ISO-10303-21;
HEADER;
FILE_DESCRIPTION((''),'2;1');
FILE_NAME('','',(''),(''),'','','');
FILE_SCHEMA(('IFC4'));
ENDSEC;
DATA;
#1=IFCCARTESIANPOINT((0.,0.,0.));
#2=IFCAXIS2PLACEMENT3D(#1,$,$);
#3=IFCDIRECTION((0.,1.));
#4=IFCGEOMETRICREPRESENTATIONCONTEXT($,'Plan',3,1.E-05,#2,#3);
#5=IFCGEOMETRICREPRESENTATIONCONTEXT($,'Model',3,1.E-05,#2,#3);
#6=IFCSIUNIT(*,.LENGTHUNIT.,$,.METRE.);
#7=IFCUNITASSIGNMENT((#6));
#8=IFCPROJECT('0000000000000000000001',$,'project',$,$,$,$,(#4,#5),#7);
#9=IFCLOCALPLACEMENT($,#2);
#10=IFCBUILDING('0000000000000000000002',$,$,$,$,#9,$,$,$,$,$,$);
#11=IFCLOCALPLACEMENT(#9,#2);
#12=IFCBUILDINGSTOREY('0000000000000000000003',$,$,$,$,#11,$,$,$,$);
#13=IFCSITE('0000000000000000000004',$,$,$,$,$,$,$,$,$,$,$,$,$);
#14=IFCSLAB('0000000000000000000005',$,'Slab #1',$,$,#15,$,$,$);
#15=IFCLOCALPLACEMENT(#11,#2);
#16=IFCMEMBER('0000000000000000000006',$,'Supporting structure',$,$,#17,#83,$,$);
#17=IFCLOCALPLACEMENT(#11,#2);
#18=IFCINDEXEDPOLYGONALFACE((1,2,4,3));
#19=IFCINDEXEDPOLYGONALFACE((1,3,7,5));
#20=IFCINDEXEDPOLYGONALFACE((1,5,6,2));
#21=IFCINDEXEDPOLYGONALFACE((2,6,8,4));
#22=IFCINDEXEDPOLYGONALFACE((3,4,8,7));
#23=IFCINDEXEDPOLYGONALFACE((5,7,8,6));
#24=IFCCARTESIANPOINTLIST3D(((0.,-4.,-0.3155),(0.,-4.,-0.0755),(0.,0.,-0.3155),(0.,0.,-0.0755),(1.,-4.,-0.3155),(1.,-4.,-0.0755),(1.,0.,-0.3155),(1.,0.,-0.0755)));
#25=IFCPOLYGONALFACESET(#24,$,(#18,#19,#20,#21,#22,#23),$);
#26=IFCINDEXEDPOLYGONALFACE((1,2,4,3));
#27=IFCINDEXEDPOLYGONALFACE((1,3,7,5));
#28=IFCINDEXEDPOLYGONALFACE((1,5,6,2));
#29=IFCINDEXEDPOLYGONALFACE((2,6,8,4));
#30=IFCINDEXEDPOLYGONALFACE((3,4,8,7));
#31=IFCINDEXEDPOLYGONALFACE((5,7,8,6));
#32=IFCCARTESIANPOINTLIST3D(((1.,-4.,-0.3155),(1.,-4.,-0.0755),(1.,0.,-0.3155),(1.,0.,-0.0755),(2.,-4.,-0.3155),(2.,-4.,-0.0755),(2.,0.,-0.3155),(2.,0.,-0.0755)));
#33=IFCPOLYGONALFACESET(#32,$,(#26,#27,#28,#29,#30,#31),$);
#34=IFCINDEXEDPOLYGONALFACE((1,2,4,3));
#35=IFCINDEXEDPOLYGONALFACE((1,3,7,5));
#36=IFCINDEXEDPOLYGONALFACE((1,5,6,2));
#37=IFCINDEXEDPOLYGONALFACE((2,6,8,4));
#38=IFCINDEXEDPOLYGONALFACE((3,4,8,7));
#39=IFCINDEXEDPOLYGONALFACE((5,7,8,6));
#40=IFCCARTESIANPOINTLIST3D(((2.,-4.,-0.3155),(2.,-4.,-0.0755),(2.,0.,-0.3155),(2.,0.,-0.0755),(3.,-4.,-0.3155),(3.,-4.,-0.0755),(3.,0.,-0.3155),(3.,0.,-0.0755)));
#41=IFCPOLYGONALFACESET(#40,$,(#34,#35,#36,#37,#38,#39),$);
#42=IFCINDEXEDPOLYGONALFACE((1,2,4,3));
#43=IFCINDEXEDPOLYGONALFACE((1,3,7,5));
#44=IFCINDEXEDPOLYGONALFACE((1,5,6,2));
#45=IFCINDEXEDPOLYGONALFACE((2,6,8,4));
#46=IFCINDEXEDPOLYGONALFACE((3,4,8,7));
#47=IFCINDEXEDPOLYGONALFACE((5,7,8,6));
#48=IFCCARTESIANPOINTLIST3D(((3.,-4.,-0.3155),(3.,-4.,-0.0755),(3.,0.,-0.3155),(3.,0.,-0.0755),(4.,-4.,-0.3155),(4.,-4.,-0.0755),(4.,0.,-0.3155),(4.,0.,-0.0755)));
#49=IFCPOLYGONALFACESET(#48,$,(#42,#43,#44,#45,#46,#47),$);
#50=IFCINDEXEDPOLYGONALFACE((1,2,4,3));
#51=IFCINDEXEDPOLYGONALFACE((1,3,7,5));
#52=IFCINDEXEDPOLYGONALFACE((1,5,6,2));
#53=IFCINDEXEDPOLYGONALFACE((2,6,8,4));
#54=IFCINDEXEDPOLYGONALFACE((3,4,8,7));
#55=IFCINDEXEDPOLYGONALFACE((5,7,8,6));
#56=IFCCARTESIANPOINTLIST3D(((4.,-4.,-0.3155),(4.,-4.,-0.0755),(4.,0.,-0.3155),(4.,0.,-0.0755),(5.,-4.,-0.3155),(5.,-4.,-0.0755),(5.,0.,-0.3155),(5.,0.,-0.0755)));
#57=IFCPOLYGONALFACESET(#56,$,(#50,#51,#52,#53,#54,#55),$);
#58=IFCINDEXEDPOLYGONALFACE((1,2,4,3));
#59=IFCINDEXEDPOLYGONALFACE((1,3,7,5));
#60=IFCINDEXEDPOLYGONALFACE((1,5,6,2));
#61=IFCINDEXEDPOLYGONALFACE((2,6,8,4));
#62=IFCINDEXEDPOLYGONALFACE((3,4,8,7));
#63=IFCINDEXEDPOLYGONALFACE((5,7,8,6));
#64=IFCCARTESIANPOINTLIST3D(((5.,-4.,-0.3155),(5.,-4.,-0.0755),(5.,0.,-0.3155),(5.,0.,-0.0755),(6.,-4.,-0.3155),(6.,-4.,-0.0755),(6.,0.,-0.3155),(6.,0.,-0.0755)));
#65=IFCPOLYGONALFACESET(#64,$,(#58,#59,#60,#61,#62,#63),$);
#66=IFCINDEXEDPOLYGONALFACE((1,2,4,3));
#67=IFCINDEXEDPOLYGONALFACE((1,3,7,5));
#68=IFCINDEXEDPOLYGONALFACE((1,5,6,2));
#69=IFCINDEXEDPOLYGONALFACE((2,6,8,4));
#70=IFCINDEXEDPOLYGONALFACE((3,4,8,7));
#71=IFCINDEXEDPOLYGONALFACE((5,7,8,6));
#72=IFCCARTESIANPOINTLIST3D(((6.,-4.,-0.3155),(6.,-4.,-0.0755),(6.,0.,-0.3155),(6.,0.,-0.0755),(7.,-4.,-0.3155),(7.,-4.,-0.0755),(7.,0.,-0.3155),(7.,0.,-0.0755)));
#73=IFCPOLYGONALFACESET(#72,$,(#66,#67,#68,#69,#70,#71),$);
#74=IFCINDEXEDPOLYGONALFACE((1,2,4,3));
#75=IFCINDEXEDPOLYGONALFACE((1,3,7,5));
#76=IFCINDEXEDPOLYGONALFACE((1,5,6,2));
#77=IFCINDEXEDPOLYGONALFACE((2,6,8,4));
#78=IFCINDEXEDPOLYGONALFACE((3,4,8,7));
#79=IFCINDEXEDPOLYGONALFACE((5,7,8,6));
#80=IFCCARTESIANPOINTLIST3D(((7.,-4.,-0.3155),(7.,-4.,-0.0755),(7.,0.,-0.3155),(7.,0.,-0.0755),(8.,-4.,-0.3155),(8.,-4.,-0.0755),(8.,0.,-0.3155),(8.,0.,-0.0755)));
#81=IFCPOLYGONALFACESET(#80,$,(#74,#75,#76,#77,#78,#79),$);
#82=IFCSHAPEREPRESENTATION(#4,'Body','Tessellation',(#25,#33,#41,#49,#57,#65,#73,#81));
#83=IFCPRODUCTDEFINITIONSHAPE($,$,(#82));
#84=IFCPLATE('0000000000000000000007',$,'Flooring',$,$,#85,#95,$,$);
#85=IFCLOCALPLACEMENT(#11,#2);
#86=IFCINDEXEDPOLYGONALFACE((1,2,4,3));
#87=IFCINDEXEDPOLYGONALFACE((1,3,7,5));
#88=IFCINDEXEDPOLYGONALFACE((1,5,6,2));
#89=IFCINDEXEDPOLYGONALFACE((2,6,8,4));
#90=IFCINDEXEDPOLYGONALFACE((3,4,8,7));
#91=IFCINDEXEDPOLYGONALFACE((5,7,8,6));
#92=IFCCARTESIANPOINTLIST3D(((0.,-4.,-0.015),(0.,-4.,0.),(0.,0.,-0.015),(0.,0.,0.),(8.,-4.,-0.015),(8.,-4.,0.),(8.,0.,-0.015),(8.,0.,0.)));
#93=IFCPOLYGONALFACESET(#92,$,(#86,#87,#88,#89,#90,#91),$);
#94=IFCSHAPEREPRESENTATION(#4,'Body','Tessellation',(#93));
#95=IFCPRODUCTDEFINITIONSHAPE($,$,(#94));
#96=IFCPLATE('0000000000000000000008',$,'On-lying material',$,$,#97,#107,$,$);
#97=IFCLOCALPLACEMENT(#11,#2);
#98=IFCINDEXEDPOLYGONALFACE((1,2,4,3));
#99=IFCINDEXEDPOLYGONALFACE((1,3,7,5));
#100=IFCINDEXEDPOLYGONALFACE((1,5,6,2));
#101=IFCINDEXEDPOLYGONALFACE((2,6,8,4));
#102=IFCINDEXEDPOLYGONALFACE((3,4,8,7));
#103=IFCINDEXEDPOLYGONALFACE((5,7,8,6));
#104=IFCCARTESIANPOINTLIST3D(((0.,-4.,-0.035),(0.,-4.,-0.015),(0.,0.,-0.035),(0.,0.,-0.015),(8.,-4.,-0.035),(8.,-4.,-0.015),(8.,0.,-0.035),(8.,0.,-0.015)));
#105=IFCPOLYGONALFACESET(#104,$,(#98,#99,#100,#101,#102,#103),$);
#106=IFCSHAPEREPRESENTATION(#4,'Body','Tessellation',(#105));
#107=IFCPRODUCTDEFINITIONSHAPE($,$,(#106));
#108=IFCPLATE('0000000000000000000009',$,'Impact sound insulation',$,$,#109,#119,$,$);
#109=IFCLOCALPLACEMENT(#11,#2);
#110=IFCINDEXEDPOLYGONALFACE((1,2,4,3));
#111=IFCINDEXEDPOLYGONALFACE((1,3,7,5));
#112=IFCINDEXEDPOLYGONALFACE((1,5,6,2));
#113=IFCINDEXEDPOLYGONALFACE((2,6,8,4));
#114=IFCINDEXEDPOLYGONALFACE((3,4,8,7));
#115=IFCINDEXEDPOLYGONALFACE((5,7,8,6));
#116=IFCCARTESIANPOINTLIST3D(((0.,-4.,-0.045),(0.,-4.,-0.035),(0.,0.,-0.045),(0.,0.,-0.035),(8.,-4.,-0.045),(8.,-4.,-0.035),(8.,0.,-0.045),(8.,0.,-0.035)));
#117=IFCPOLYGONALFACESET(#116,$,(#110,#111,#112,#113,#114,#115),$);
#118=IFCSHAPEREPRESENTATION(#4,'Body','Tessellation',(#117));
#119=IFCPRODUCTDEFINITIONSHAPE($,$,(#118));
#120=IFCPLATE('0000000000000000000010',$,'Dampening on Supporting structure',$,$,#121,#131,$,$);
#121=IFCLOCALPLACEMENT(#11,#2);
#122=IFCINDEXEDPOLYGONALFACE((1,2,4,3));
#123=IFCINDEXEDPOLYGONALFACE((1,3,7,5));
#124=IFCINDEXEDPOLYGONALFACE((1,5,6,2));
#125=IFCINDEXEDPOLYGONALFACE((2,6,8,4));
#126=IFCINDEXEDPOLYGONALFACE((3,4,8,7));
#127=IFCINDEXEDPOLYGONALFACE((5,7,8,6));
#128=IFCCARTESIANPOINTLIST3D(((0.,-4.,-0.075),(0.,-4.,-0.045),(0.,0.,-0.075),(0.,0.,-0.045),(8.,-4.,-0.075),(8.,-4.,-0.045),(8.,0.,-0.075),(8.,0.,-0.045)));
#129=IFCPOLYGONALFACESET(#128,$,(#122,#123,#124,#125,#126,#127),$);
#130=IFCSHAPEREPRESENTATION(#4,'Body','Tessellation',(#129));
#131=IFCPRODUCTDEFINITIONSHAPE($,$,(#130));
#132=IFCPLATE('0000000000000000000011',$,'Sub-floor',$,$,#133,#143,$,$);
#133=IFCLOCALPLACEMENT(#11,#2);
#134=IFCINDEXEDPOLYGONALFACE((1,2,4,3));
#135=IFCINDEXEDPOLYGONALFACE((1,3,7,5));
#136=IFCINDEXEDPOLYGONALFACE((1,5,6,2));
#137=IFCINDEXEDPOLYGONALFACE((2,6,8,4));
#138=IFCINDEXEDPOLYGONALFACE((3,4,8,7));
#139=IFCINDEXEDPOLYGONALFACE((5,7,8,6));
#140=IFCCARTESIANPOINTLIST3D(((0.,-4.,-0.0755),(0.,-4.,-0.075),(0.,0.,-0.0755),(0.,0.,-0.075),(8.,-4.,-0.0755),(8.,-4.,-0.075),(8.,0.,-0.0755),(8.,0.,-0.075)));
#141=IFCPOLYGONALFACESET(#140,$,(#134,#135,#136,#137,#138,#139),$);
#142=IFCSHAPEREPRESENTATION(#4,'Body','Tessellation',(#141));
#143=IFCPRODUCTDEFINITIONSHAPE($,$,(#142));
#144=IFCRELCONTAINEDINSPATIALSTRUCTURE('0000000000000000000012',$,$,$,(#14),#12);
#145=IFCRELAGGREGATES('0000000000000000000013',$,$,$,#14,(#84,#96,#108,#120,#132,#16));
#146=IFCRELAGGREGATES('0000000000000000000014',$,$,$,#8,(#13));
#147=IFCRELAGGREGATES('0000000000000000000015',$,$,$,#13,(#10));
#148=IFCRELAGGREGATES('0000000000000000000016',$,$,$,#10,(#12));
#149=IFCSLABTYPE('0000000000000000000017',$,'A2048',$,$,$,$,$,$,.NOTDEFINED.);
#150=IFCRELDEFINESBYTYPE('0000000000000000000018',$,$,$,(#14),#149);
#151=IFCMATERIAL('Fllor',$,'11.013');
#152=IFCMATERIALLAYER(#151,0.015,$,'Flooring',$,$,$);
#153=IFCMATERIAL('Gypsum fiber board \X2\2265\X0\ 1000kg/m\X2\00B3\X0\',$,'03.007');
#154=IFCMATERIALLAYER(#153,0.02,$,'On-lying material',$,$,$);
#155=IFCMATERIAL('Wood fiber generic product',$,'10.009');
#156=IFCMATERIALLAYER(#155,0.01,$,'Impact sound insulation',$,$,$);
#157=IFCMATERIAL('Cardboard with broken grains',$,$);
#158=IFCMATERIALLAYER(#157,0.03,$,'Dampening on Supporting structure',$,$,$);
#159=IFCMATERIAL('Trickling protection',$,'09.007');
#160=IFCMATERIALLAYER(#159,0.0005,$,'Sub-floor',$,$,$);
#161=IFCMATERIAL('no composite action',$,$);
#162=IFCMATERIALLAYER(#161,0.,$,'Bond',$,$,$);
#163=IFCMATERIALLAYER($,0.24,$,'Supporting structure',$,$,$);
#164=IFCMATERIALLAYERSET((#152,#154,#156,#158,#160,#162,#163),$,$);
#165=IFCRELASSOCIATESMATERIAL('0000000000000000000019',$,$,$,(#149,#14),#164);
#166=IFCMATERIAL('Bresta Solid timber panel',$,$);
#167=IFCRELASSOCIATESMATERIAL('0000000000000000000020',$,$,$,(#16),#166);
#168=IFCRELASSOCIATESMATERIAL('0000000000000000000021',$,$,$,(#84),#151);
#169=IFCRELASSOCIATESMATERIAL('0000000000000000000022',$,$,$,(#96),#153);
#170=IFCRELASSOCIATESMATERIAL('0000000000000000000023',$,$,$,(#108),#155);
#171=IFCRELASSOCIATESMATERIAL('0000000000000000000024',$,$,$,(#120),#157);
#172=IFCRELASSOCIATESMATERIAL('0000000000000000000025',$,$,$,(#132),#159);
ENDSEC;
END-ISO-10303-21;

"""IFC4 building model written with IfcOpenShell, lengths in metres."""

from ifc_helpers import new_model, si_unit, direction, frame, frame_2d, origin, origin_with_axes, place, context, project, spatial, rectangle, extrude, material, layer, layer_set, type_object, element, aggregate, save


model = new_model("IFC4")

# Units and contexts
plan_context = context("Plan", 3, precision=1e-05, world=origin(), true_north=direction((0.0, 1.0)))
model_context = context("Model", 3, precision=1e-05, world=origin(), true_north=direction((0.0, 1.0)))
ifc_project = project(units=[si_unit("LENGTHUNIT", "METRE")], contexts=[plan_context, model_context])

# Site, building, storey
site = spatial("IfcSite", under=ifc_project)
building_placement = place(None, origin())
building = spatial("IfcBuilding", under=site, at=building_placement)
storey_placement = place(building_placement, origin())
storey = spatial("IfcBuildingStorey", under=building, at=storey_placement)

# Slab, member, plates
ifc_material_1 = material(Name="Fllor", Category="11.013")
ifc_layer_1 = layer(ifc_material_1, 0.015, Name="Flooring")
ifc_material_2 = material(Name="Gypsum fiber board ≥ 1000kg/m³", Category="03.007")
ifc_layer_2 = layer(ifc_material_2, 0.02, Name="On-lying material")
ifc_material_3 = material(Name="Wood fiber generic product", Category="10.009")
ifc_layer_3 = layer(ifc_material_3, 0.01, Name="Impact sound insulation")
ifc_material_4 = material(Name="Cardboard with broken grains")
ifc_layer_4 = layer(ifc_material_4, 0.03, Name="Dampening on Supporting structure")
ifc_material_5 = material(Name="Trickling protection", Category="09.007")
ifc_layer_5 = layer(ifc_material_5, 0.0005, Name="Sub-floor")
ifc_material_6 = material(Name="no composite action")
ifc_layer_6 = layer(ifc_material_6, 0.0, Name="Bond")
ifc_layer_7 = layer(None, 0.24, Name="Supporting structure")
ifc_layer_set = layer_set([ifc_layer_1, ifc_layer_2, ifc_layer_3, ifc_layer_4, ifc_layer_5, ifc_layer_6, ifc_layer_7])
slab_type = type_object("IfcSlabType", Name="A2048", PredefinedType="NOTDEFINED", material=ifc_layer_set)
slab_placement = place(None, frame((0.0, 0.0, 0.0), z_axis=(0.0, 0.0, -1.0), x_axis=(1.0, 0.0, 0.0)))
slab = element("IfcSlab", 1, at=slab_placement, inside=storey, type_object=slab_type, material=ifc_layer_set, Name="Slab #1")
ifc_material_7 = material(Name="Bresta Solid timber panel")
member_placement = place(slab_placement, origin())
member = element("IfcMember", 2, at=member_placement, material=ifc_material_7, Name="Supporting structure", context=plan_context, shape_type="SweptSolid", body=[
    extrude(rectangle(XDim=1.0, YDim=0.24, at=frame_2d((0.5, 0.12), x_axis=(1.0, 0.0))), frame((0.0, 4.0, 0.0755), z_axis=(0.0, -1.0, 0.0), x_axis=(1.0, 0.0, 0.0)), (0.0, 0.0, 1.0), 4.0),
    extrude(rectangle(XDim=1.0, YDim=0.24, at=frame_2d((0.5, 0.12), x_axis=(1.0, 0.0))), frame((1.0, 4.0, 0.0755), z_axis=(0.0, -1.0, 0.0), x_axis=(1.0, 0.0, 0.0)), (0.0, 0.0, 1.0), 4.0),
    extrude(rectangle(XDim=1.0, YDim=0.24, at=frame_2d((0.5, 0.12), x_axis=(1.0, 0.0))), frame((2.0, 4.0, 0.0755), z_axis=(0.0, -1.0, 0.0), x_axis=(1.0, 0.0, 0.0)), (0.0, 0.0, 1.0), 4.0),
    extrude(rectangle(XDim=1.0, YDim=0.24, at=frame_2d((0.5, 0.12), x_axis=(1.0, 0.0))), frame((3.0, 4.0, 0.0755), z_axis=(0.0, -1.0, 0.0), x_axis=(1.0, 0.0, 0.0)), (0.0, 0.0, 1.0), 4.0),
    extrude(rectangle(XDim=1.0, YDim=0.24, at=frame_2d((0.5, 0.12), x_axis=(1.0, 0.0))), frame((4.0, 4.0, 0.0755), z_axis=(0.0, -1.0, 0.0), x_axis=(1.0, 0.0, 0.0)), (0.0, 0.0, 1.0), 4.0),
    extrude(rectangle(XDim=1.0, YDim=0.24, at=frame_2d((0.5, 0.12), x_axis=(1.0, 0.0))), frame((5.0, 4.0, 0.0755), z_axis=(0.0, -1.0, 0.0), x_axis=(1.0, 0.0, 0.0)), (0.0, 0.0, 1.0), 4.0),
    extrude(rectangle(XDim=1.0, YDim=0.24, at=frame_2d((0.5, 0.12), x_axis=(1.0, 0.0))), frame((6.0, 4.0, 0.0755), z_axis=(0.0, -1.0, 0.0), x_axis=(1.0, 0.0, 0.0)), (0.0, 0.0, 1.0), 4.0),
    extrude(rectangle(XDim=1.0, YDim=0.24, at=frame_2d((0.5, 0.12), x_axis=(1.0, 0.0))), frame((7.0, 4.0, 0.0755), z_axis=(0.0, -1.0, 0.0), x_axis=(1.0, 0.0, 0.0)), (0.0, 0.0, 1.0), 4.0),
])
plate_1_placement = place(slab_placement, origin())
plate_1 = element("IfcPlate", 3, at=plate_1_placement, material=ifc_material_1, Name="Flooring", context=plan_context, shape_type="SweptSolid", body=[
    extrude(rectangle(XDim=8.0, YDim=4.0, at=frame_2d((4.0, 2.0), x_axis=(1.0, 0.0))), origin_with_axes(), (0.0, 0.0, 1.0), 0.015),
])
plate_2_placement = place(slab_placement, origin())
plate_2 = element("IfcPlate", 4, at=plate_2_placement, material=ifc_material_2, Name="On-lying material", context=plan_context, shape_type="SweptSolid", body=[
    extrude(rectangle(XDim=8.0, YDim=4.0, at=frame_2d((4.0, 2.0), x_axis=(1.0, 0.0))), frame((0.0, 0.0, 0.015), z_axis=(0.0, 0.0, 1.0), x_axis=(1.0, 0.0, 0.0)), (0.0, 0.0, 1.0), 0.02),
])
plate_3_placement = place(slab_placement, origin())
plate_3 = element("IfcPlate", 5, at=plate_3_placement, material=ifc_material_3, Name="Impact sound insulation", context=plan_context, shape_type="SweptSolid", body=[
    extrude(rectangle(XDim=8.0, YDim=4.0, at=frame_2d((4.0, 2.0), x_axis=(1.0, 0.0))), frame((0.0, 0.0, 0.035), z_axis=(0.0, 0.0, 1.0), x_axis=(1.0, 0.0, 0.0)), (0.0, 0.0, 1.0), 0.01),
])
plate_4_placement = place(slab_placement, origin())
plate_4 = element("IfcPlate", 6, at=plate_4_placement, material=ifc_material_4, Name="Dampening on Supporting structure", context=plan_context, shape_type="SweptSolid", body=[
    extrude(rectangle(XDim=8.0, YDim=4.0, at=frame_2d((4.0, 2.0), x_axis=(1.0, 0.0))), frame((0.0, 0.0, 0.045), z_axis=(0.0, 0.0, 1.0), x_axis=(1.0, 0.0, 0.0)), (0.0, 0.0, 1.0), 0.03),
])
plate_5_placement = place(slab_placement, origin())
plate_5 = element("IfcPlate", 7, at=plate_5_placement, material=ifc_material_5, Name="Sub-floor", context=plan_context, shape_type="SweptSolid", body=[
    extrude(rectangle(XDim=8.0, YDim=4.0, at=frame_2d((4.0, 2.0), x_axis=(1.0, 0.0))), frame((0.0, 0.0, 0.075), z_axis=(0.0, 0.0, 1.0), x_axis=(1.0, 0.0, 0.0)), (0.0, 0.0, 1.0), 0.0005),
])
aggregate(slab, [plate_1, plate_2, plate_3, plate_4, plate_5, member])

save(model, "model.ifc")
